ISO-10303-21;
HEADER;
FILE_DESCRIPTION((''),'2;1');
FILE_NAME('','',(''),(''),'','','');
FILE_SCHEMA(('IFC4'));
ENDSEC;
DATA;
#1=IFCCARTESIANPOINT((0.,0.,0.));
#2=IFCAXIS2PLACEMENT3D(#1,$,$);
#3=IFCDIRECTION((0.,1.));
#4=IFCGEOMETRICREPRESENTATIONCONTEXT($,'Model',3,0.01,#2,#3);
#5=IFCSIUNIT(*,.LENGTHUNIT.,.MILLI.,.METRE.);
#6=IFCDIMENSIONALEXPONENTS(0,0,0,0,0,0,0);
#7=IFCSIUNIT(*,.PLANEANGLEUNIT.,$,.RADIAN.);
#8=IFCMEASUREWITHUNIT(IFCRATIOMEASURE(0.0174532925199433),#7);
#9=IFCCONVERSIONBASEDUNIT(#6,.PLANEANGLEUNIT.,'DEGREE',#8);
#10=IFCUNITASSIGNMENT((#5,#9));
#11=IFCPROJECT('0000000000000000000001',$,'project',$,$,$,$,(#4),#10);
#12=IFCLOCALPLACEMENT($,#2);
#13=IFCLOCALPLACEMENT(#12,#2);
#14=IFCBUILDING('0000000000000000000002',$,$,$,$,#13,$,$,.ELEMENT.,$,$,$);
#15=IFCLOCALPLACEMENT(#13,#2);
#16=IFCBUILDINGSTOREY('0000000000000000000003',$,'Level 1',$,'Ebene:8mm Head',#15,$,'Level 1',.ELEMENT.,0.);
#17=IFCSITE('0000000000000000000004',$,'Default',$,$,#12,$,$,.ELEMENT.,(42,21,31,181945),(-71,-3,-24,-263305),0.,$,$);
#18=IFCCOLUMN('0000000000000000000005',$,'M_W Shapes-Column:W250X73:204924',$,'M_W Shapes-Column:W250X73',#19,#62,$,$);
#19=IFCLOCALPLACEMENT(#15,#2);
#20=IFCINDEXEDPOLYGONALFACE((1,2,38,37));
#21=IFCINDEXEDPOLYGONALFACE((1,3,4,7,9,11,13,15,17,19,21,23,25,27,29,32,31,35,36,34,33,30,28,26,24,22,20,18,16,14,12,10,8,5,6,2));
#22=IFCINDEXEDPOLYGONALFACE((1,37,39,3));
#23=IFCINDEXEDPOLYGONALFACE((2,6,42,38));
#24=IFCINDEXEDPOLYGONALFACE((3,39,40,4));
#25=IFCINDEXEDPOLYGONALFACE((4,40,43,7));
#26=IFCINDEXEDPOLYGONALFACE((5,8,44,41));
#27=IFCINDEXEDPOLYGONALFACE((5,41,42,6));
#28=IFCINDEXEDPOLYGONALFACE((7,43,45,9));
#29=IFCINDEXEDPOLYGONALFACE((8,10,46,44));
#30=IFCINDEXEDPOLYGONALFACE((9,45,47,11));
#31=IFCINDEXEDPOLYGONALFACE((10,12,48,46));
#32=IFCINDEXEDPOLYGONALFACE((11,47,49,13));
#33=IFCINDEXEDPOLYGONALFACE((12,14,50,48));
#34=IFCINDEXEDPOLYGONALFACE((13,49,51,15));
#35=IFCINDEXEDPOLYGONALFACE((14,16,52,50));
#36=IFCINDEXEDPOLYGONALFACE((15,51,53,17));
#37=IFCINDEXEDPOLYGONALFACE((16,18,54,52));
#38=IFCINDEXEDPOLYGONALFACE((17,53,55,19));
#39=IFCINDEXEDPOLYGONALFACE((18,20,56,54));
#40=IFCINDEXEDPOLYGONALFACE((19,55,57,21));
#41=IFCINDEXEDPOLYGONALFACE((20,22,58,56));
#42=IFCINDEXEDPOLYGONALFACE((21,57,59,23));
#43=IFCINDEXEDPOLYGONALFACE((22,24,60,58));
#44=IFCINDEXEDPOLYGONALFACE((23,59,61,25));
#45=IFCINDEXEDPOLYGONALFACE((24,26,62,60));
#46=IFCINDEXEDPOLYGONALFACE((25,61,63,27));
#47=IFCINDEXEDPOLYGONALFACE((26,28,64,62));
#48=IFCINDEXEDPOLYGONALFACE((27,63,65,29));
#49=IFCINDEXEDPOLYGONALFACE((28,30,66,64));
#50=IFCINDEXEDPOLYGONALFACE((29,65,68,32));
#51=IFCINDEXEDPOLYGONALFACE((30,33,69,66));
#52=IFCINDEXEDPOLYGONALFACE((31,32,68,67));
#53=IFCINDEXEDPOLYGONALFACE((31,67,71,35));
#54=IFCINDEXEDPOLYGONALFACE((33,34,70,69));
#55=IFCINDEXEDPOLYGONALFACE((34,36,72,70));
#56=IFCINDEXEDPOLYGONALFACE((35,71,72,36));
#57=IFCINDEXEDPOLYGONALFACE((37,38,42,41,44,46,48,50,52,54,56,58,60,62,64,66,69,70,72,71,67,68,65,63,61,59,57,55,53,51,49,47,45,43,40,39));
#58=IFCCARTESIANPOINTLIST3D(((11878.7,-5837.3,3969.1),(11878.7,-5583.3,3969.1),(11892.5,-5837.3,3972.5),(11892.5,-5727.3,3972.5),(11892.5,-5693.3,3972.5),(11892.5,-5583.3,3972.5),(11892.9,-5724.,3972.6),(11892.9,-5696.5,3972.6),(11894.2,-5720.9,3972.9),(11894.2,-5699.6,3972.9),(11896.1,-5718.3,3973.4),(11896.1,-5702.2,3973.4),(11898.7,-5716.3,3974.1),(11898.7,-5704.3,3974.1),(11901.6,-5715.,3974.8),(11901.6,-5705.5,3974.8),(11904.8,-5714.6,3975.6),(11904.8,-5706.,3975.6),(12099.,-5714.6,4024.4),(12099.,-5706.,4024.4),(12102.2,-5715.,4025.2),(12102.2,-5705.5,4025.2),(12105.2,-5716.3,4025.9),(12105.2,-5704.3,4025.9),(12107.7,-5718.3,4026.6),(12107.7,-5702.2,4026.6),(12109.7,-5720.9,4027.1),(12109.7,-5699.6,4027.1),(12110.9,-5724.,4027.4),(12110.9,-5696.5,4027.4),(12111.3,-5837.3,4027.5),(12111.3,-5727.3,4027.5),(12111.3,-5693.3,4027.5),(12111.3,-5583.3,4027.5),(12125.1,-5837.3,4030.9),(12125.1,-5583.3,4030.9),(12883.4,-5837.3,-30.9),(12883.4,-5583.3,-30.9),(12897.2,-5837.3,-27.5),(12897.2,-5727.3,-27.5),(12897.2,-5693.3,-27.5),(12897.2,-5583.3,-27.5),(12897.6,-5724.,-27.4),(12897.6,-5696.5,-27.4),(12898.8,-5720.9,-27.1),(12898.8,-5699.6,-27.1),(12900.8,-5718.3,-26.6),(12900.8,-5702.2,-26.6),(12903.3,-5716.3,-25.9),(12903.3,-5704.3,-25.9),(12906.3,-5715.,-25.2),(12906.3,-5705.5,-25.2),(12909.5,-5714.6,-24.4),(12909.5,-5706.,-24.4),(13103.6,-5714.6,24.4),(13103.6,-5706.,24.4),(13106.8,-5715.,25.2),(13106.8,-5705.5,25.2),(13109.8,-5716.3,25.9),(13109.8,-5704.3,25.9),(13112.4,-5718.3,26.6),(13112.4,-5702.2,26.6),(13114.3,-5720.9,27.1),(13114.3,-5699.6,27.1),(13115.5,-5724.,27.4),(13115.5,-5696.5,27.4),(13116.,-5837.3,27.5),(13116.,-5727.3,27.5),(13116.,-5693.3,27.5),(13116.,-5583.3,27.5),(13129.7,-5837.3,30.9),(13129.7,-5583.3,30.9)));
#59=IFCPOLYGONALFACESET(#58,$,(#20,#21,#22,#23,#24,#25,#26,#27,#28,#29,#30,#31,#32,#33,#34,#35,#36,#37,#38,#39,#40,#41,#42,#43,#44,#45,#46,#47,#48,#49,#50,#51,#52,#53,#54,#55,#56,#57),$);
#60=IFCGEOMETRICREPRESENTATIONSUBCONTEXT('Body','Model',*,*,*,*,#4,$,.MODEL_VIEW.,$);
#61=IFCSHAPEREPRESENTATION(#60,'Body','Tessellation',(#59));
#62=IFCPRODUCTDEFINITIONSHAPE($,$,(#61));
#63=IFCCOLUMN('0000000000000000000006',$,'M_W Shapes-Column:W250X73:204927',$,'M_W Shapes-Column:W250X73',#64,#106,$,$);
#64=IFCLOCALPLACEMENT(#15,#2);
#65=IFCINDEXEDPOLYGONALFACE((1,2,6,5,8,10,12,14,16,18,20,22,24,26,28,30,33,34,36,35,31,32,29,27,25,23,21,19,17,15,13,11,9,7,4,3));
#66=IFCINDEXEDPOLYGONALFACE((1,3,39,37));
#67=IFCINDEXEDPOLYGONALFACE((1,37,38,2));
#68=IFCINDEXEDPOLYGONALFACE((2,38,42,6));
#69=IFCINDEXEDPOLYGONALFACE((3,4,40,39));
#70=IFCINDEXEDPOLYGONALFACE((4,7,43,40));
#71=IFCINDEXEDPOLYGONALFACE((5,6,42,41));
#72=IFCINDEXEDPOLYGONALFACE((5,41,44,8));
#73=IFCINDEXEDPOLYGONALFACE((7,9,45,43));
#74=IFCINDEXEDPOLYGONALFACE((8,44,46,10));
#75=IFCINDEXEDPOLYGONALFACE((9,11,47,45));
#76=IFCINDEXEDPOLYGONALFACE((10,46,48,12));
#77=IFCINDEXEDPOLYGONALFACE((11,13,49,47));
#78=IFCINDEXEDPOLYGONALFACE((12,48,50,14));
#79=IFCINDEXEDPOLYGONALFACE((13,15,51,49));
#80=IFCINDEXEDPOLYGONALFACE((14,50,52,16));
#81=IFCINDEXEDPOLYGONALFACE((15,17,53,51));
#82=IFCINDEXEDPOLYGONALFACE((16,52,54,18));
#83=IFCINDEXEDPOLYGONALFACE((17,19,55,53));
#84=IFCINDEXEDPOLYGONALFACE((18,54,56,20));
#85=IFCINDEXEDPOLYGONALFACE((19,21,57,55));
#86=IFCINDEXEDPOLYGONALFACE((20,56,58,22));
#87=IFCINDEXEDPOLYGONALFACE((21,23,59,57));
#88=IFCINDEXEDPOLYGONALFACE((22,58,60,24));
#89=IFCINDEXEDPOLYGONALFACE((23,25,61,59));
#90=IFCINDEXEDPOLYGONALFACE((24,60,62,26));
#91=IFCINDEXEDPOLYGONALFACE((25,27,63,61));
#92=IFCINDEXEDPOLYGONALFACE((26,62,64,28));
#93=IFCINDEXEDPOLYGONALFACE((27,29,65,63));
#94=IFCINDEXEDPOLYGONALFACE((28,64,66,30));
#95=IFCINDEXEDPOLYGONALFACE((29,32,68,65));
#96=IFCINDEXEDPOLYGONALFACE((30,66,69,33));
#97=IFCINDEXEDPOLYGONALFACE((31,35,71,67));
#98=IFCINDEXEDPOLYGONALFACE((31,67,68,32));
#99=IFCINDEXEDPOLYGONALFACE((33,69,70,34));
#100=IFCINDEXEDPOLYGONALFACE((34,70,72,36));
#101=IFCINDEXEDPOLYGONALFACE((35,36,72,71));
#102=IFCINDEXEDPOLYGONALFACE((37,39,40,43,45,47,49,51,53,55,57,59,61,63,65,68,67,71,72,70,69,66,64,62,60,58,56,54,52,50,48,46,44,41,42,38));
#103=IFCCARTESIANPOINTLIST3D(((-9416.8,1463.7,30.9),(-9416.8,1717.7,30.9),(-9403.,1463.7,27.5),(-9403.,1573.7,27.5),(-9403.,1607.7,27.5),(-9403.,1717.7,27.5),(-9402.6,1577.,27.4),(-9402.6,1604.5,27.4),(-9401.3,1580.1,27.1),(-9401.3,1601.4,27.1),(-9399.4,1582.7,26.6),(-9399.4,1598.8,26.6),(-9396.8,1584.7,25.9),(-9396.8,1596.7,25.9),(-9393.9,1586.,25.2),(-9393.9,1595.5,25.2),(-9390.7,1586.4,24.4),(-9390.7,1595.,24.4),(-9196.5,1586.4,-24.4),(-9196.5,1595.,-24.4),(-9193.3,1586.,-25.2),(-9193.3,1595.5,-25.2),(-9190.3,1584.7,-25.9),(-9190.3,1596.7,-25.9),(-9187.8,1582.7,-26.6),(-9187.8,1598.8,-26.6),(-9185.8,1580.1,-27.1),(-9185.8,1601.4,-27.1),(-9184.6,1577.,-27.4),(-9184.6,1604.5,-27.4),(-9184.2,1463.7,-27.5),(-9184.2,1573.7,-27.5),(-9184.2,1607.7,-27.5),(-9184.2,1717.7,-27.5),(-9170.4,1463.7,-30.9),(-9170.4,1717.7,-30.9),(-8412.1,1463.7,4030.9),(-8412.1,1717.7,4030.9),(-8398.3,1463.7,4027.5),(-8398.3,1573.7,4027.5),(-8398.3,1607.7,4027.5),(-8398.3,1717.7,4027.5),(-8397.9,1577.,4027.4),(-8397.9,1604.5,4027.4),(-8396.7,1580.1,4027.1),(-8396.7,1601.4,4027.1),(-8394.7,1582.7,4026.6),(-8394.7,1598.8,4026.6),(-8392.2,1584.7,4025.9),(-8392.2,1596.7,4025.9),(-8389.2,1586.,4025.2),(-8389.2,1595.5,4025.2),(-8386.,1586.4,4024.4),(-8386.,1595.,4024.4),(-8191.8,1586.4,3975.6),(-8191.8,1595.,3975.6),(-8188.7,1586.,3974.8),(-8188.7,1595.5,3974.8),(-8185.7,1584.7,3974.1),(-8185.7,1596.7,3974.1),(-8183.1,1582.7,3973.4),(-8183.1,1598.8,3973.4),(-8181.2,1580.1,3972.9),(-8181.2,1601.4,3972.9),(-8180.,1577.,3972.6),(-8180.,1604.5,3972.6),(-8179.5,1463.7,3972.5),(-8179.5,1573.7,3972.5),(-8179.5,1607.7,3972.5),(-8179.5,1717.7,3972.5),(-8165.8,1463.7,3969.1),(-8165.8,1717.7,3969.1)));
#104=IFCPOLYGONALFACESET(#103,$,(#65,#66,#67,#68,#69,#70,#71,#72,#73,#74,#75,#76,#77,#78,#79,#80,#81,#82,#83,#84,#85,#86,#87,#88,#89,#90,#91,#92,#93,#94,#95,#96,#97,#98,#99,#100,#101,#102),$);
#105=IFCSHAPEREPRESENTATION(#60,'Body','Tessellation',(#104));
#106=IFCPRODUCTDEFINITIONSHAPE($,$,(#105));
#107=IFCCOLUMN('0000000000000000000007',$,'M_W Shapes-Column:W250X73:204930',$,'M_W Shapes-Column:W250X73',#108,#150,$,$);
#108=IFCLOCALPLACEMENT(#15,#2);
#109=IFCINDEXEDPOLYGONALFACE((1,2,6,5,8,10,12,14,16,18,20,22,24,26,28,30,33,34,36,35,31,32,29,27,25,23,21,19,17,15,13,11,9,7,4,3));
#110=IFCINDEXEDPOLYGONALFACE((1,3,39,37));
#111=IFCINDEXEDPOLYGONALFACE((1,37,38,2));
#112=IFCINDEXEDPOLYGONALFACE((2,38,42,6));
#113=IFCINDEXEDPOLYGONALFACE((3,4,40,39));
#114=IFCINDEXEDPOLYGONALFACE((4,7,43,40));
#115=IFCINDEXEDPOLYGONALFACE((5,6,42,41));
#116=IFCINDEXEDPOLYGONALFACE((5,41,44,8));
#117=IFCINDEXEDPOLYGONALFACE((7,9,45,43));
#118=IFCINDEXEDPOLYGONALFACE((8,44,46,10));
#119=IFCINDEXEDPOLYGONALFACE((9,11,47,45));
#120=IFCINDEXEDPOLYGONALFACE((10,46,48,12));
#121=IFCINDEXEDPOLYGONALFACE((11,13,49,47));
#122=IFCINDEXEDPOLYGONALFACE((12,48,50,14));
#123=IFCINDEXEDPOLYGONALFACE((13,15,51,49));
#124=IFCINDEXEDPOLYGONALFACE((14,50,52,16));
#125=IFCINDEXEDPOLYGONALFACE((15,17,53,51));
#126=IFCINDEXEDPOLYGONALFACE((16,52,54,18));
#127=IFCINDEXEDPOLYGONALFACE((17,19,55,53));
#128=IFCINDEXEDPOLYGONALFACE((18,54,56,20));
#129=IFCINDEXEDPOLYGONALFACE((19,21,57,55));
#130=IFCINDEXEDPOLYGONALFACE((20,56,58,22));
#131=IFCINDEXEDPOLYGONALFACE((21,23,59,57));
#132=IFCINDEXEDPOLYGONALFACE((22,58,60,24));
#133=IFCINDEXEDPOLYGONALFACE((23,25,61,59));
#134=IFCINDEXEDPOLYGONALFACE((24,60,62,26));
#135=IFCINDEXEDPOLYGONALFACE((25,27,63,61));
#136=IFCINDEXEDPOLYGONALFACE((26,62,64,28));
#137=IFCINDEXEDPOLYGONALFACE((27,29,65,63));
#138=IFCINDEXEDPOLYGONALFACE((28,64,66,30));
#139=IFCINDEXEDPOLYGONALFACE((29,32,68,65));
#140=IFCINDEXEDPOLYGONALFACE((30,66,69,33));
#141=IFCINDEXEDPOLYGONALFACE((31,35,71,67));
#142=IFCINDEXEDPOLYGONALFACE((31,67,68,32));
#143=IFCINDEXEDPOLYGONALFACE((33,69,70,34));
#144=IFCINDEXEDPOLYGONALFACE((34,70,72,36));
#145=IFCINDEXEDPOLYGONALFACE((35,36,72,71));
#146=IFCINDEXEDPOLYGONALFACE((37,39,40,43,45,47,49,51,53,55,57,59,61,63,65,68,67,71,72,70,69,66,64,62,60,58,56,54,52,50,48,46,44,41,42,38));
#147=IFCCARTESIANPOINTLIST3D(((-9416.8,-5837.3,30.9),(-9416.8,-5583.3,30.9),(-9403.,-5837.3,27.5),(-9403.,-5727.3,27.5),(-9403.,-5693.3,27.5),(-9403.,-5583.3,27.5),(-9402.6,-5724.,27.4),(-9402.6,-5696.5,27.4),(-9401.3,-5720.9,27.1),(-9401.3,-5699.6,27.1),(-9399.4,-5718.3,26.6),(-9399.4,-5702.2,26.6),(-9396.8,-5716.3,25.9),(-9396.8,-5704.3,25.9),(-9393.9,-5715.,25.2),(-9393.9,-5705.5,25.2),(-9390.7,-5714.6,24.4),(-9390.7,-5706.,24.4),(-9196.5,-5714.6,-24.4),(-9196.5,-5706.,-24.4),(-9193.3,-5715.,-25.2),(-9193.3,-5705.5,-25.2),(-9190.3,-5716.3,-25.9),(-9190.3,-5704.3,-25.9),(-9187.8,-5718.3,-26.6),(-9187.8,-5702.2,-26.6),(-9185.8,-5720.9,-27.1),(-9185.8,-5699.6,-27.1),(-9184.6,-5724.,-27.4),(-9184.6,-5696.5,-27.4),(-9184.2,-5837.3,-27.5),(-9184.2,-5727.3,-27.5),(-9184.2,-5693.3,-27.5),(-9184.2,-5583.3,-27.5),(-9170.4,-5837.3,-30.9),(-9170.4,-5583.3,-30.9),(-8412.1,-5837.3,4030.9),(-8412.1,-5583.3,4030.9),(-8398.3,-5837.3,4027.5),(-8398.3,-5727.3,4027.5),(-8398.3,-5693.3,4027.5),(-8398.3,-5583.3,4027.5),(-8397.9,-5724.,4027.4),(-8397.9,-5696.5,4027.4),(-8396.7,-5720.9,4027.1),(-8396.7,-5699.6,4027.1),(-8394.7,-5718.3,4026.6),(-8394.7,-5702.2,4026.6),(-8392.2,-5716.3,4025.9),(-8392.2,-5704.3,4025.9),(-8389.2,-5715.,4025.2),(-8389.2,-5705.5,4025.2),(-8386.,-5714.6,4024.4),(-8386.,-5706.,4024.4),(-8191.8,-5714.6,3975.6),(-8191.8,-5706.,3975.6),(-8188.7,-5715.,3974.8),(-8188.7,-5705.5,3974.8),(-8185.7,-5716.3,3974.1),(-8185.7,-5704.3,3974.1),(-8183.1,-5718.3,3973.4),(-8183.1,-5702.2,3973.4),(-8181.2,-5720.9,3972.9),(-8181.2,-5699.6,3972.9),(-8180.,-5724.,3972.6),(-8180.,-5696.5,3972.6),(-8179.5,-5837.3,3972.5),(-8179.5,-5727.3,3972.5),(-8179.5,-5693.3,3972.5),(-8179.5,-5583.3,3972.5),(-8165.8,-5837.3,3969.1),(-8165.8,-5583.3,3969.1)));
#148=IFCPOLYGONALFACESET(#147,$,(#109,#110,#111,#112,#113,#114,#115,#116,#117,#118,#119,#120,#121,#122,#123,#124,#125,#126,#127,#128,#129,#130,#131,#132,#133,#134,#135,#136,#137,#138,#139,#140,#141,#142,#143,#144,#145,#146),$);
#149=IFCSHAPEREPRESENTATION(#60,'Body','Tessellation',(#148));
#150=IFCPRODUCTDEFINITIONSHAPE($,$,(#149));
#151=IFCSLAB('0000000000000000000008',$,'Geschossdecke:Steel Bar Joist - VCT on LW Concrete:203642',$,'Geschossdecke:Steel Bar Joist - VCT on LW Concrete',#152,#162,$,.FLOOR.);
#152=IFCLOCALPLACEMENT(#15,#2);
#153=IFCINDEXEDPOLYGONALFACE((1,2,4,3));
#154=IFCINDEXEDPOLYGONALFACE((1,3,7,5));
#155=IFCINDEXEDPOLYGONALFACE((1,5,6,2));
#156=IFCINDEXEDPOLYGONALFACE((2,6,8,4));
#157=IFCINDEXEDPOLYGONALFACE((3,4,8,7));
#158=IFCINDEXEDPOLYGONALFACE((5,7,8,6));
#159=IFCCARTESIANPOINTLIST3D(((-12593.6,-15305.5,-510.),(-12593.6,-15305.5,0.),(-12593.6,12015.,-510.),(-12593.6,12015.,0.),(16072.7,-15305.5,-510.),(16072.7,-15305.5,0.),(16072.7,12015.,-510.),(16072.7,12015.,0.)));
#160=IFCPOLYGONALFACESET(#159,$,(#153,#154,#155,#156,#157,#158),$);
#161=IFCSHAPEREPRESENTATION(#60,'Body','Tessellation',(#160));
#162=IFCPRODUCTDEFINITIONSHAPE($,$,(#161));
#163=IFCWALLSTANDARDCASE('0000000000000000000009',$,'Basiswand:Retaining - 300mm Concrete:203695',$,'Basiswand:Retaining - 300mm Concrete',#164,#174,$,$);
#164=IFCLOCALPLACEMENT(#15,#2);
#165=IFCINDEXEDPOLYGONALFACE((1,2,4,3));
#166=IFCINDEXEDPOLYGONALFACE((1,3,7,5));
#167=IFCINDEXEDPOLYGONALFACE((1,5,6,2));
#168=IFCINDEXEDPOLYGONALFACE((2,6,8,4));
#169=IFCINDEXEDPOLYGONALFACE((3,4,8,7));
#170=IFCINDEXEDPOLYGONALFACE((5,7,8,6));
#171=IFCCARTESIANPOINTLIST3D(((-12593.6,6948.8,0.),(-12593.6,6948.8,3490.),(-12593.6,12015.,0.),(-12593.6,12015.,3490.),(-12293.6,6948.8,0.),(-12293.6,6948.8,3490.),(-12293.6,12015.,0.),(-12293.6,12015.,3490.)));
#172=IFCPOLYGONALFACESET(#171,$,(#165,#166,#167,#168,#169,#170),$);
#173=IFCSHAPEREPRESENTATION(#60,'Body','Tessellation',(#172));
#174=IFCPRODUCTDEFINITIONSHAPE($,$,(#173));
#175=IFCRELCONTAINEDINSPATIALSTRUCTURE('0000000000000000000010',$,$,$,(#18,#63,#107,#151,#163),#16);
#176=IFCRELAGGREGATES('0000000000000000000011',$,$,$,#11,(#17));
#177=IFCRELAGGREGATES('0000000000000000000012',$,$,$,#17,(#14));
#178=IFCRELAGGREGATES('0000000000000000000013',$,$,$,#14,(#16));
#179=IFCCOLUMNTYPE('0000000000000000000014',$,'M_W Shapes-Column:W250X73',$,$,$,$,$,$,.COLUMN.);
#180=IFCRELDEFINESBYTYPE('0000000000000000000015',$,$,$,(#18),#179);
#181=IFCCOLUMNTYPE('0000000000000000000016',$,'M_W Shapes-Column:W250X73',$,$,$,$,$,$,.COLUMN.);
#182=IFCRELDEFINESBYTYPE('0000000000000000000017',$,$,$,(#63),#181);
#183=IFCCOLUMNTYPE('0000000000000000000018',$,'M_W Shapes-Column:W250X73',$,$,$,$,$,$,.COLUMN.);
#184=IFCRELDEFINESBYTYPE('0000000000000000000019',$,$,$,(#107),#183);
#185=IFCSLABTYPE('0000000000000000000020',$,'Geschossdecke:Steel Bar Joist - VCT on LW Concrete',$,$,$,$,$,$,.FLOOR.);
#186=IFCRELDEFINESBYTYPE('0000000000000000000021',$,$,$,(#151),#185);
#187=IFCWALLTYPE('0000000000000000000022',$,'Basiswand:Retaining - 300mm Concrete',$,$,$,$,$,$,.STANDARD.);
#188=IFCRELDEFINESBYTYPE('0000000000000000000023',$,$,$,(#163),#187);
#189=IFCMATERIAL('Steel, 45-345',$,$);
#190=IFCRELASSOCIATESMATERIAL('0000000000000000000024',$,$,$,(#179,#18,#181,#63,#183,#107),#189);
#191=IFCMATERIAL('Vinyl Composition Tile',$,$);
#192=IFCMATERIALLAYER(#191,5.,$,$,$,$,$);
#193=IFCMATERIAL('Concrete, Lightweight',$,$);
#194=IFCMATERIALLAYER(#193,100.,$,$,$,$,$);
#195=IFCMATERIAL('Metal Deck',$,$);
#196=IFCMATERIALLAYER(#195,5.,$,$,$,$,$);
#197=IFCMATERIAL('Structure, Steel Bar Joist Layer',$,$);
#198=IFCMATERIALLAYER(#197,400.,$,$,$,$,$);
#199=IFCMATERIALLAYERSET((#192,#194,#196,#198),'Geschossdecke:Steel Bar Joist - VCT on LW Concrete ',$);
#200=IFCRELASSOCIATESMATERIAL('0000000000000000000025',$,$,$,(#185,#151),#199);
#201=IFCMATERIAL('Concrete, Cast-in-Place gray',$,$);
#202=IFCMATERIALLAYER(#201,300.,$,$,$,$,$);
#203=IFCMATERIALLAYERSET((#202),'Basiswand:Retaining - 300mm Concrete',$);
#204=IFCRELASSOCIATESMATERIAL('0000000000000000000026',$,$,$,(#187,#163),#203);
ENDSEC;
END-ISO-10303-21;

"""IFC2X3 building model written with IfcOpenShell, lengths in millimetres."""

from ifc_helpers import new_model, entity, si_unit, converted_unit, direction, frame, frame_2d, origin, origin_2d_with_axis, place, context, subcontext, project, spatial, polyline, rectangle, i_section, extrude, clip, bounded_halfspace, source, transform, mapped, material, layer, layer_set, layer_usage, type_object, type_shapes, element, save


model = new_model("IFC2X3")

# Units and contexts
model_context = context("Model", 3, precision=0.01, world=origin(), true_north=direction((0.0, 1.0)))
body_context = subcontext(model_context, "Body", "Model", "MODEL_VIEW")
ifc_project = project(units=[si_unit("LENGTHUNIT", "METRE", prefix="MILLI"), converted_unit("PLANEANGLEUNIT", "DEGREE", entity("IfcRatioMeasure", 0.0174532925199433), si_unit("PLANEANGLEUNIT", "RADIAN"), dimensions=[0, 0, 0, 0, 0, 0, 0])], contexts=[model_context])

# Site, building, storey
site_placement = place(None, origin())
site = spatial("IfcSite", under=ifc_project, at=site_placement, Name="Default", CompositionType="ELEMENT", RefLatitude=(42, 21, 31, 181945), RefLongitude=(-71, -3, -24, -263305), RefElevation=0.0)
building_placement = place(site_placement, origin())
building = spatial("IfcBuilding", under=site, at=building_placement, CompositionType="ELEMENT")
storey_placement = place(building_placement, origin())
storey = spatial("IfcBuildingStorey", under=building, at=storey_placement, Name="Level 1", ObjectType="Ebene:8mm Head", LongName="Level 1", CompositionType="ELEMENT", Elevation=0.0)

# Columns
ifc_material_1 = material(Name="Steel, 45-345")
column_type_1 = type_object("IfcColumnType", Name="M_W Shapes-Column:W250X73", PredefinedType="COLUMN", material=ifc_material_1)
shared_shape_1 = source(origin(), body_context, "Body", "SweptSolid", [
    extrude(i_section(OverallWidth=254.0, OverallDepth=254.0, WebThickness=8.6, FlangeThickness=14.2, FilletRadius=12.7, at=frame_2d((0.0, 0.0), x_axis=(1.0, 0.0))), frame((13006.6, -5710.3, 0.0), z_axis=(-0.243596, 0.0, 0.969877), x_axis=(0.0, -1.0, 0.0)), (0.0, 0.0, 1.0), 4124.2),
])
type_shapes(column_type_1, [shared_shape_1])
column_1_placement = place(storey_placement, origin())
element("IfcColumn", 1, at=column_1_placement, inside=storey, type_object=column_type_1, material=ifc_material_1, Name="M_W Shapes-Column:W250X73:204924", ObjectType="M_W Shapes-Column:W250X73", context=body_context, shape_type="MappedRepresentation", body=[
    mapped(shared_shape_1, transform((0.0, 0.0, 0.0), scale=1.0)),
])
column_type_2 = type_object("IfcColumnType", Name="M_W Shapes-Column:W250X73", PredefinedType="COLUMN", material=ifc_material_1)
shared_shape_2 = source(origin(), body_context, "Body", "SweptSolid", [
    extrude(i_section(OverallWidth=254.0, OverallDepth=254.0, WebThickness=8.6, FlangeThickness=14.2, FilletRadius=12.7, at=frame_2d((0.0, 0.0), x_axis=(1.0, 0.0))), frame((-9293.6, 1590.7, 0.0), z_axis=(0.243596, 0.0, 0.969877), x_axis=(0.0, -1.0, 0.0)), (0.0, 0.0, 1.0), 4124.2),
])
type_shapes(column_type_2, [shared_shape_2])
column_2_placement = place(storey_placement, origin())
element("IfcColumn", 2, at=column_2_placement, inside=storey, type_object=column_type_2, material=ifc_material_1, Name="M_W Shapes-Column:W250X73:204927", ObjectType="M_W Shapes-Column:W250X73", context=body_context, shape_type="MappedRepresentation", body=[
    mapped(shared_shape_2, transform((0.0, 0.0, 0.0), scale=1.0)),
])
column_type_3 = type_object("IfcColumnType", Name="M_W Shapes-Column:W250X73", PredefinedType="COLUMN", material=ifc_material_1)
shared_shape_3 = source(origin(), body_context, "Body", "SweptSolid", [
    extrude(i_section(OverallWidth=254.0, OverallDepth=254.0, WebThickness=8.6, FlangeThickness=14.2, FilletRadius=12.7, at=frame_2d((0.0, 0.0), x_axis=(1.0, 0.0))), frame((-9293.6, -5710.3, 0.0), z_axis=(0.243596, 0.0, 0.969877), x_axis=(0.0, -1.0, 0.0)), (0.0, 0.0, 1.0), 4124.2),
])
type_shapes(column_type_3, [shared_shape_3])
column_3_placement = place(storey_placement, origin())
element("IfcColumn", 3, at=column_3_placement, inside=storey, type_object=column_type_3, material=ifc_material_1, Name="M_W Shapes-Column:W250X73:204930", ObjectType="M_W Shapes-Column:W250X73", context=body_context, shape_type="MappedRepresentation", body=[
    mapped(shared_shape_3, transform((0.0, 0.0, 0.0), scale=1.0)),
])

# Slab
ifc_material_2 = material(Name="Vinyl Composition Tile")
ifc_layer_1 = layer(ifc_material_2, 5.0)
ifc_material_3 = material(Name="Concrete, Lightweight")
ifc_layer_2 = layer(ifc_material_3, 100.0)
ifc_material_4 = material(Name="Metal Deck")
ifc_layer_3 = layer(ifc_material_4, 5.0)
ifc_material_5 = material(Name="Structure, Steel Bar Joist Layer")
ifc_layer_4 = layer(ifc_material_5, 400.0)
ifc_layer_set_1 = layer_set([ifc_layer_1, ifc_layer_2, ifc_layer_3, ifc_layer_4], Name="Geschossdecke:Steel Bar Joist - VCT on LW Concrete ")
ifc_layer_usage_1 = layer_usage(ifc_layer_set_1, "AXIS3", "POSITIVE", 0.0)
slab_type = type_object("IfcSlabType", Name="Geschossdecke:Steel Bar Joist - VCT on LW Concrete", PredefinedType="FLOOR", material=ifc_layer_set_1)
slab_placement = place(storey_placement, origin())
element("IfcSlab", 4, at=slab_placement, inside=storey, type_object=slab_type, material=ifc_layer_usage_1, Name="Geschossdecke:Steel Bar Joist - VCT on LW Concrete:203642", ObjectType="Geschossdecke:Steel Bar Joist - VCT on LW Concrete", PredefinedType="FLOOR", context=body_context, shape_type="SweptSolid", body=[
    extrude(rectangle(XDim=27320.5, YDim=28666.3, at=origin_2d_with_axis()), frame((1739.6, -1645.2, 0.0), z_axis=(0.0, 0.0, -1.0), x_axis=(0.0, 1.0, 0.0)), (0.0, 0.0, 1.0), 510.0),
])

# Wall
ifc_material_6 = material(Name="Concrete, Cast-in-Place gray")
ifc_layer_5 = layer(ifc_material_6, 300.0)
ifc_layer_set_2 = layer_set([ifc_layer_5], Name="Basiswand:Retaining - 300mm Concrete")
ifc_layer_usage_2 = layer_usage(ifc_layer_set_2, "AXIS2", "NEGATIVE", 150.0)
wall_type = type_object("IfcWallType", Name="Basiswand:Retaining - 300mm Concrete", PredefinedType="STANDARD", material=ifc_layer_set_2)
wall_1_placement = place(storey_placement, frame((-12443.6, 6948.8, 0.0), z_axis=(0.0, 0.0, 1.0), x_axis=(0.0, 1.0, 0.0)))
element("IfcWallStandardCase", 5, at=wall_1_placement, inside=storey, type_object=wall_type, material=ifc_layer_usage_2, Name="Basiswand:Retaining - 300mm Concrete:203695", ObjectType="Basiswand:Retaining - 300mm Concrete", context=body_context, shape_type="Clipping", body=[
    clip(extrude(rectangle(XDim=5066.3, YDim=300.0, at=frame_2d((2533.1, 0.0), x_axis=(-1.0, 0.0))), origin(), (0.0, 0.0, 1.0), 3490.0), bounded_halfspace(frame((0.0, -150.0, 3490.0), z_axis=(0.0, 0.0, -1.0), x_axis=(-1.0, 0.0, 0.0)), True, frame((0.0, -150.0, 3490.0)), polyline([(0.0, 0.0), (4766.3, 0.0), (5066.3, 0.0), (5066.3, 300.0), (0.0, 300.0), (0.0, 0.0)]))),
])

save(model, "model.ifc")
